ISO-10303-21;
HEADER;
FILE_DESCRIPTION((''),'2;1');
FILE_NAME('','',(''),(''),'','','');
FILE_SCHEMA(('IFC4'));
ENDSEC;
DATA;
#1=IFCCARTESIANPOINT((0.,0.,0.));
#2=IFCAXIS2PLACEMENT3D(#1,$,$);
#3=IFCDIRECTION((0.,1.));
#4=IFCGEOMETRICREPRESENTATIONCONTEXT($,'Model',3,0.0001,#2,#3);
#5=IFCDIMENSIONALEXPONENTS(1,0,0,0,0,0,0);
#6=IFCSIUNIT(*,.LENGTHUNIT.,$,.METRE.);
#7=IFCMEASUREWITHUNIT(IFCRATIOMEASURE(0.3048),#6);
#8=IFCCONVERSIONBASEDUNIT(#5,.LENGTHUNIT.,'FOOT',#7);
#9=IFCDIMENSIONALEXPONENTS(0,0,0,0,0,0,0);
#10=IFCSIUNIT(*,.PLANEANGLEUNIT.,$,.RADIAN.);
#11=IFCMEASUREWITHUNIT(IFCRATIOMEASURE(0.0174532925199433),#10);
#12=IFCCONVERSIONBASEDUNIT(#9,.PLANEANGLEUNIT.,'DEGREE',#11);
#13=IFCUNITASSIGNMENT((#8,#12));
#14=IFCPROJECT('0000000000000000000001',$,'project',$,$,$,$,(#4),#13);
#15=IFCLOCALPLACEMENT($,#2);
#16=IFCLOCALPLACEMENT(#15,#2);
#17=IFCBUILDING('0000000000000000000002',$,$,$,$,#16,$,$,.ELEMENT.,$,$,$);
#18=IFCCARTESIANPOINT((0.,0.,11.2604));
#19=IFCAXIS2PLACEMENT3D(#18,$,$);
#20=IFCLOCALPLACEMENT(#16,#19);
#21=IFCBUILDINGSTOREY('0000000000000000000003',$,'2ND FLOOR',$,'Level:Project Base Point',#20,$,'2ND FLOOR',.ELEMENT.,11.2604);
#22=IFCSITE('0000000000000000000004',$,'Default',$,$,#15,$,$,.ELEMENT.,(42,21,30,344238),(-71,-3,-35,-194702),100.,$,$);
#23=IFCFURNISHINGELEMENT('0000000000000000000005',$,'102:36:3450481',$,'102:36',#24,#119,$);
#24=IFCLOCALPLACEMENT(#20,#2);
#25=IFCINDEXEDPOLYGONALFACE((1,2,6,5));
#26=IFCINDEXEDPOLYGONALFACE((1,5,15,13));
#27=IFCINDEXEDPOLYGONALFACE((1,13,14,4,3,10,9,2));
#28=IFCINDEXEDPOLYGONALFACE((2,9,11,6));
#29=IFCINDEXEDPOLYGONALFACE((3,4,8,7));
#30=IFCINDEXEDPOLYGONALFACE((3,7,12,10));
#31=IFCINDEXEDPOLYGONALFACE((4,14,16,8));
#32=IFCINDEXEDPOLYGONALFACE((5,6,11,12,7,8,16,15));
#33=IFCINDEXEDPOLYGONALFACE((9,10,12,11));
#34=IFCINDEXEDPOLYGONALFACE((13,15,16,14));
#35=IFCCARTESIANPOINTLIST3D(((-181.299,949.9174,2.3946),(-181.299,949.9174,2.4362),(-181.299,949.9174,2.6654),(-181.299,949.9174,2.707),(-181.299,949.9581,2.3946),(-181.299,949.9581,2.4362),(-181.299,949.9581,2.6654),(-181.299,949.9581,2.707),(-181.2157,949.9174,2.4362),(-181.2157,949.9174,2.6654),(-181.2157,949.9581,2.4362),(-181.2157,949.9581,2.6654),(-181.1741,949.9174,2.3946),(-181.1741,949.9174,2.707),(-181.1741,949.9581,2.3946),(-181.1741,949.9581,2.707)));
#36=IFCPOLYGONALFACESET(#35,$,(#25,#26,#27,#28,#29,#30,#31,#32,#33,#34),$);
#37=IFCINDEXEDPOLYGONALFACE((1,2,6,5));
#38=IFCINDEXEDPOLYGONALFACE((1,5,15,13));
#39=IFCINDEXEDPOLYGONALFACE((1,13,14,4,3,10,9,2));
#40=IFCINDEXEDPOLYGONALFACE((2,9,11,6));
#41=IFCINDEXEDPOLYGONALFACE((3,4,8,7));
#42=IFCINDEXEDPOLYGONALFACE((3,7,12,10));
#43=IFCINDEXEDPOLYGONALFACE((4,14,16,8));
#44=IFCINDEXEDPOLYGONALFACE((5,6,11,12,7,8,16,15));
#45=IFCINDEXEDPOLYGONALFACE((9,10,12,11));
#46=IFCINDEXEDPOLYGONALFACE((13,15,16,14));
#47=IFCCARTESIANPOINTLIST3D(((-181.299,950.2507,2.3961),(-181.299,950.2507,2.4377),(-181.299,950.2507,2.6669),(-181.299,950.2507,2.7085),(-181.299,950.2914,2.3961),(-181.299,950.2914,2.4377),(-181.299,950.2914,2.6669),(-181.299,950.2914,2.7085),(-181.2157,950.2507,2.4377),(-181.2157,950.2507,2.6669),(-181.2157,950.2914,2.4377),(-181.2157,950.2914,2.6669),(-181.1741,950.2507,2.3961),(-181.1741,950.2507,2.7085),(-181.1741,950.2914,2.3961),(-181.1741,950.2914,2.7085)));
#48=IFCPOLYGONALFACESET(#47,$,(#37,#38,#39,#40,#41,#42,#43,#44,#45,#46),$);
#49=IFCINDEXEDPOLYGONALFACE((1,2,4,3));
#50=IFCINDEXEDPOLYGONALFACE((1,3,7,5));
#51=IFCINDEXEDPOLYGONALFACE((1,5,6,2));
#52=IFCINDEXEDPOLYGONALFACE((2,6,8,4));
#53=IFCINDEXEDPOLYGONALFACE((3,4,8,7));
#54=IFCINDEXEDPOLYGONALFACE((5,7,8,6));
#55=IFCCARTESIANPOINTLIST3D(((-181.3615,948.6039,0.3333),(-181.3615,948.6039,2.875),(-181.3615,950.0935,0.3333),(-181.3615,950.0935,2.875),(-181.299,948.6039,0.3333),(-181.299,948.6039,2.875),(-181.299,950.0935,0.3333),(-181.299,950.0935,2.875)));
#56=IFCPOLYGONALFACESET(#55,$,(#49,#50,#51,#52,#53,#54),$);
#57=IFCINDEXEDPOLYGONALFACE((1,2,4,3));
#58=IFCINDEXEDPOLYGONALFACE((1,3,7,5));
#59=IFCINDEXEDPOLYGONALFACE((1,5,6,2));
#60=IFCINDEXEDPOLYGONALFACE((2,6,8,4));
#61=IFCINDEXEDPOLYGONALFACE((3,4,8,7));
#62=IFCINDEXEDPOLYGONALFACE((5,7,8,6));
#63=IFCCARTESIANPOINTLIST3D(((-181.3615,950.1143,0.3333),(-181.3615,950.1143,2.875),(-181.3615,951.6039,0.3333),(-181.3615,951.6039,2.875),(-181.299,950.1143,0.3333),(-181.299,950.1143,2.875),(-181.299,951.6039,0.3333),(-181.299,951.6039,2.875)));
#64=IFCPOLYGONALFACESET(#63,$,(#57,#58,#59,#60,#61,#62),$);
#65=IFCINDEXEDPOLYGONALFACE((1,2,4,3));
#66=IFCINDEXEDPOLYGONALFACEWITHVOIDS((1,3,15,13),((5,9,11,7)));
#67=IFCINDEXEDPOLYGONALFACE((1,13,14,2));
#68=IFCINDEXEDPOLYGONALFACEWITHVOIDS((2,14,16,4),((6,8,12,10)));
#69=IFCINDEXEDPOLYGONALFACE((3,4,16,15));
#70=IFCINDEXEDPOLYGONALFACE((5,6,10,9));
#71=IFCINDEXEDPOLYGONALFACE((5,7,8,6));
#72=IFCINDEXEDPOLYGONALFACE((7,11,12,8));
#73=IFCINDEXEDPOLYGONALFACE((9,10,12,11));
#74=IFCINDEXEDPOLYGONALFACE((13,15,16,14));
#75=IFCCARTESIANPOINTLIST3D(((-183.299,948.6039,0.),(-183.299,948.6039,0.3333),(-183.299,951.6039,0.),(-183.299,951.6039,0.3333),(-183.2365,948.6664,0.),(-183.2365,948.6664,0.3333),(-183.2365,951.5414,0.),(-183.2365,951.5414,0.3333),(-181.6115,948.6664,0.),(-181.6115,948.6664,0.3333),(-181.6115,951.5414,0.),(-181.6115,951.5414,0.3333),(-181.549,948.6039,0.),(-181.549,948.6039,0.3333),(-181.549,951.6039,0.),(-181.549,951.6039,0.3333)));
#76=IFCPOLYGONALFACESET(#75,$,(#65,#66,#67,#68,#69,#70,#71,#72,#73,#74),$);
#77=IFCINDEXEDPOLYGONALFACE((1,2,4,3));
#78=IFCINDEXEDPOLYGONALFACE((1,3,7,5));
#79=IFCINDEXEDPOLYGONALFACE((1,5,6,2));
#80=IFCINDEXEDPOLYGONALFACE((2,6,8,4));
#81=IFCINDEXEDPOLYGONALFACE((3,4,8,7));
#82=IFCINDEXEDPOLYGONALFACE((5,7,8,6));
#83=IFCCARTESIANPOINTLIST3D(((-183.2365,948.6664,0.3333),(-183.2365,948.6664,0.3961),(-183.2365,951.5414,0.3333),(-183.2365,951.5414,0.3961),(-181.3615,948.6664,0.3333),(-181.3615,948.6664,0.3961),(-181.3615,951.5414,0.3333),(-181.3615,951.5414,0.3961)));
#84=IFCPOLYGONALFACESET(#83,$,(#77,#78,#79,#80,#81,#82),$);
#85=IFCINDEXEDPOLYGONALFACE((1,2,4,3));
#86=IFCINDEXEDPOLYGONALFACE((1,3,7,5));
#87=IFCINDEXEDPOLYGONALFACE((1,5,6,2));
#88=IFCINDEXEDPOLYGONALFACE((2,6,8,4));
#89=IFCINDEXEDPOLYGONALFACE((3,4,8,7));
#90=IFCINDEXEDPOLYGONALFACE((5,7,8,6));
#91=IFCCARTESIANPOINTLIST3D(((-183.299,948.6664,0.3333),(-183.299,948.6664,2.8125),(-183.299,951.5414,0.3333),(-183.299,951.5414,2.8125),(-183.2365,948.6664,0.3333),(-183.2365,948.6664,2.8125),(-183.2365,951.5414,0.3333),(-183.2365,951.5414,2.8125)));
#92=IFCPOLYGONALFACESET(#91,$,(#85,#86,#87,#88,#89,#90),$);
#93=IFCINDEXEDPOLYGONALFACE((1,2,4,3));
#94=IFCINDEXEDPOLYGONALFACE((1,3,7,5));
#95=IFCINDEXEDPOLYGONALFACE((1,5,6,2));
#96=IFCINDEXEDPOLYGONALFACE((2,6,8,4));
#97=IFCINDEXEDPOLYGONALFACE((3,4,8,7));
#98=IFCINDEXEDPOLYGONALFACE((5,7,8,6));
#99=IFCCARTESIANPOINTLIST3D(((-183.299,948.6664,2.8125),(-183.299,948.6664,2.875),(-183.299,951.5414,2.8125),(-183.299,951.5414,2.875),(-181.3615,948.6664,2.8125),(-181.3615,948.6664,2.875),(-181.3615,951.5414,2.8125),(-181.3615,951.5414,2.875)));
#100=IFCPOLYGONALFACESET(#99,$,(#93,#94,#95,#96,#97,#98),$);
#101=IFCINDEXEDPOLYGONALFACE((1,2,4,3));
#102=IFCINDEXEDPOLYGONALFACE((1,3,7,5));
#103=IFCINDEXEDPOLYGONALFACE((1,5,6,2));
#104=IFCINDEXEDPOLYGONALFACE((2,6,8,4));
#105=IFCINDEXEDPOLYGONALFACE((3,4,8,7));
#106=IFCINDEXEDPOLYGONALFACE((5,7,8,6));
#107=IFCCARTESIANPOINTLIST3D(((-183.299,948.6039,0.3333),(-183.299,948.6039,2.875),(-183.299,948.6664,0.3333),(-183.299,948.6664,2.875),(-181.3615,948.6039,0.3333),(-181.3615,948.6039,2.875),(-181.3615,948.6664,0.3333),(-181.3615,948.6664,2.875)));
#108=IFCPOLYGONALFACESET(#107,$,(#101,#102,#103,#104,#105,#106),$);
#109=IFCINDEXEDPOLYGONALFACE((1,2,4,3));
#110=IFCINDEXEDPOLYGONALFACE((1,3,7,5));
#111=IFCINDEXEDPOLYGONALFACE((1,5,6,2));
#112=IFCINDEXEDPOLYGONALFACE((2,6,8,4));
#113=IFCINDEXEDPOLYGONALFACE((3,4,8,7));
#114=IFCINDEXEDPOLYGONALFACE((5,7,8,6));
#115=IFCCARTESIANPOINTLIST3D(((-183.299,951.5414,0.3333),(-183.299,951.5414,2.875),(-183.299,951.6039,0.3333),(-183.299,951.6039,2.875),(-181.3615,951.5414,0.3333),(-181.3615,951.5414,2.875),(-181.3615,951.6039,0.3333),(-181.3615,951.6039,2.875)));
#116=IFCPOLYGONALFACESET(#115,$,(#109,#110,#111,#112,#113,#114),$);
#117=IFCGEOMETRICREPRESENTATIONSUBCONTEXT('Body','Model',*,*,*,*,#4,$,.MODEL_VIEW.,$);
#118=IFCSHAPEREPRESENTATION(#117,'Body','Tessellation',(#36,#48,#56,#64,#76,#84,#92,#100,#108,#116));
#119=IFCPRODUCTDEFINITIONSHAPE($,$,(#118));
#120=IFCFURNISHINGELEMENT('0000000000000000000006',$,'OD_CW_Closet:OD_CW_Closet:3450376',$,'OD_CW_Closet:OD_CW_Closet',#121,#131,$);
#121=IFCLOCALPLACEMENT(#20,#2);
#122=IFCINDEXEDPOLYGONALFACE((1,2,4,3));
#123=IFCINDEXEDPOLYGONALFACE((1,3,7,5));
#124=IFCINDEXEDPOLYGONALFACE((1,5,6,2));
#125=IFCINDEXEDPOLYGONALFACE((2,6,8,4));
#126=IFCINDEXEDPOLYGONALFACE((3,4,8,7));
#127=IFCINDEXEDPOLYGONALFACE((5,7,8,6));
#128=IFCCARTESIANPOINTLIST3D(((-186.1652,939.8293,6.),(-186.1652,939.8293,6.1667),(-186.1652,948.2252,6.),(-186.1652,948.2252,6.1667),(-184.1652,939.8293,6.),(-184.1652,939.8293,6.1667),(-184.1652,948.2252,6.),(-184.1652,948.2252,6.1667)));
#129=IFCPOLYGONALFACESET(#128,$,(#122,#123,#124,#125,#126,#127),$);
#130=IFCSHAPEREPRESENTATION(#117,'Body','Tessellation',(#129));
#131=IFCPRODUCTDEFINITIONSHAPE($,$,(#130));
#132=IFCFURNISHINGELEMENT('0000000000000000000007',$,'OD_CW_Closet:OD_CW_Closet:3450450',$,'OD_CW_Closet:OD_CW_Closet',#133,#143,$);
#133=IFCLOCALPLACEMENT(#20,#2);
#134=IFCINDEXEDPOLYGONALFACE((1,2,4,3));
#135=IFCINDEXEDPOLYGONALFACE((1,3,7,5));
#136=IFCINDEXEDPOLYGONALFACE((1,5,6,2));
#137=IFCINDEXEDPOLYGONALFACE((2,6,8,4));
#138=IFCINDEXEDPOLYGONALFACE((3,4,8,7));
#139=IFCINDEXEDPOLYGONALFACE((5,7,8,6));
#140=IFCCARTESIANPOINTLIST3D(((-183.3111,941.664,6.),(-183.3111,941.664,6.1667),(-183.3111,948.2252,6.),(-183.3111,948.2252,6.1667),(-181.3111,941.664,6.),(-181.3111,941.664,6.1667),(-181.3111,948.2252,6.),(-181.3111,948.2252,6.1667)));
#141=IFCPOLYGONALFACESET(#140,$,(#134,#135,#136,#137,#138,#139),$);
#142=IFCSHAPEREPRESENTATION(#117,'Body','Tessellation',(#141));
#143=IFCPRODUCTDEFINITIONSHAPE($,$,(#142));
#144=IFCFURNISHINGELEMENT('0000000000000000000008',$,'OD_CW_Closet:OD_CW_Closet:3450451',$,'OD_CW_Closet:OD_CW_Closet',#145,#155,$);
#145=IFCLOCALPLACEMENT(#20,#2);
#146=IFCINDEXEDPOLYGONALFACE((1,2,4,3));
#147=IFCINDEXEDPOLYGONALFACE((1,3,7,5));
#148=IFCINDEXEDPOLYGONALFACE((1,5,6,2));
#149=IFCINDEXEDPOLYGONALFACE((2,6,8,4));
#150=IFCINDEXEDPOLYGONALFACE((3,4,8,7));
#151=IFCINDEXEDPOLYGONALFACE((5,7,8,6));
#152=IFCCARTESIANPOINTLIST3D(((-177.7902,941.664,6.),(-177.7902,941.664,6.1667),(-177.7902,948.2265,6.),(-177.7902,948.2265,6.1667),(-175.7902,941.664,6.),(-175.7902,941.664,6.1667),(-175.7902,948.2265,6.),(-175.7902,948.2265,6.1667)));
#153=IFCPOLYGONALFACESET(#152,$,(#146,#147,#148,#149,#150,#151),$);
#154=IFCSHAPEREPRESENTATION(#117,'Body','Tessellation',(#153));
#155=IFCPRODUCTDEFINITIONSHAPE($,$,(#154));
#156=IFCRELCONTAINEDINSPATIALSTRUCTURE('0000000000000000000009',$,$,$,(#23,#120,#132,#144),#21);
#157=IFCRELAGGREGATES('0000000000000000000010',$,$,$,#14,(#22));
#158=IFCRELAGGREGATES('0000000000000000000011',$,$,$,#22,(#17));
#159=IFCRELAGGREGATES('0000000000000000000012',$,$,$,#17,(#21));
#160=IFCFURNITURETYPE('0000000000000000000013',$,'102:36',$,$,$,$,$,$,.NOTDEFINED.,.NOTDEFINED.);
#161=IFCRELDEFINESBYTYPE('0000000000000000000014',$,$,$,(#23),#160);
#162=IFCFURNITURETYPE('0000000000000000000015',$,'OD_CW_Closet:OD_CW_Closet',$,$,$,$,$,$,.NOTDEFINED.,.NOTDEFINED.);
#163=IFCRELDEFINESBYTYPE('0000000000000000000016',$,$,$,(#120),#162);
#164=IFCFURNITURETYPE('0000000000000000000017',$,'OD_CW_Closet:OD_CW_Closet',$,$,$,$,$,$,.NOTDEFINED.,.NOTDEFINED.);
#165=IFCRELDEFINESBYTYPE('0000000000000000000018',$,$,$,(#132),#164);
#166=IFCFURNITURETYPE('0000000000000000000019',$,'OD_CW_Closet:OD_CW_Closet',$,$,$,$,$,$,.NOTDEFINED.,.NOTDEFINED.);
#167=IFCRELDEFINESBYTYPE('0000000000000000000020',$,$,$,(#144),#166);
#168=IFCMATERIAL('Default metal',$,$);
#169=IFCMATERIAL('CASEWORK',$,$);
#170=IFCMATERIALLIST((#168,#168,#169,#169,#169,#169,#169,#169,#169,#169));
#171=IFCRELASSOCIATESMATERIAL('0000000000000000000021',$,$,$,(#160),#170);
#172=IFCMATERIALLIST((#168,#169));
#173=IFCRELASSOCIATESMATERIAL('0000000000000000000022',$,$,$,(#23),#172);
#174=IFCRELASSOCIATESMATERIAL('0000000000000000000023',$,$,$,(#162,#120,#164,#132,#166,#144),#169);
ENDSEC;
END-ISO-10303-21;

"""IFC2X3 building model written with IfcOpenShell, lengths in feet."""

from ifc_helpers import new_model, entity, si_unit, converted_unit, direction, frame, frame_2d, origin, origin_2d_with_axis, place, context, subcontext, project, spatial, polyline, rectangle, outline, extrude, source, transform, mapped, material, material_list, type_object, type_shapes, element, save


model = new_model("IFC2X3")

# Units and contexts
model_context = context("Model", 3, precision=0.0001, world=origin(), true_north=direction((0.0, 1.0)))
body_context = subcontext(model_context, "Body", "Model", "MODEL_VIEW")
ifc_project = project(units=[converted_unit("LENGTHUNIT", "FOOT", entity("IfcRatioMeasure", 0.3048), si_unit("LENGTHUNIT", "METRE"), dimensions=[1, 0, 0, 0, 0, 0, 0]), converted_unit("PLANEANGLEUNIT", "DEGREE", entity("IfcRatioMeasure", 0.0174532925199433), si_unit("PLANEANGLEUNIT", "RADIAN"), dimensions=[0, 0, 0, 0, 0, 0, 0])], contexts=[model_context])

# Site, building, storey
site_placement = place(None, origin())
site = spatial("IfcSite", under=ifc_project, at=site_placement, Name="Default", CompositionType="ELEMENT", RefLatitude=(42, 21, 30, 344238), RefLongitude=(-71, -3, -35, -194702), RefElevation=100.0)
building_placement = place(site_placement, origin())
building = spatial("IfcBuilding", under=site, at=building_placement, CompositionType="ELEMENT")
storey_placement = place(building_placement, frame((0.0, 0.0, 11.2604)))
storey = spatial("IfcBuildingStorey", under=building, at=storey_placement, Name="2ND FLOOR", ObjectType="Level:Project Base Point", LongName="2ND FLOOR", CompositionType="ELEMENT", Elevation=11.2604)

# Furnishing elements
ifc_material_1 = material(Name="Default metal")
ifc_material_2 = material(Name="CASEWORK")
ifc_material_list_1 = material_list([ifc_material_1, ifc_material_1, ifc_material_2, ifc_material_2, ifc_material_2, ifc_material_2, ifc_material_2, ifc_material_2, ifc_material_2, ifc_material_2])
furniture_type_1 = type_object("IfcFurnitureType", Name="102:36", material=ifc_material_list_1)
shared_shape_1 = source(origin(), body_context, "Body", "SweptSolid", [
    extrude(outline(polyline([(-0.0521, -0.1146), (-0.0521, -0.1562), (0.0729, -0.1562), (0.0729, 0.1562), (-0.0521, 0.1562), (-0.0521, 0.1146), (0.0313, 0.1146), (0.0313, -0.1146), (-0.0521, -0.1146)])), frame((0.2073, 2.0521, 2.5508), z_axis=(-1.0, 0.0, 0.0), x_axis=(0.0, 1.0, 0.0)), (0.0, 0.0, -1.0), 0.0407),
    extrude(outline(polyline([(-0.0521, -0.1146), (-0.0521, -0.1562), (0.0729, -0.1562), (0.0729, 0.1562), (-0.0521, 0.1562), (-0.0521, 0.1146), (0.0313, 0.1146), (0.0313, -0.1146), (-0.0521, -0.1146)])), frame((-0.126, 2.0521, 2.5523), z_axis=(-1.0, 0.0, 0.0), x_axis=(0.0, 1.0, 0.0)), (0.0, 0.0, -1.0), 0.0407),
    extrude(rectangle(XDim=1.4896, YDim=0.0625, at=frame_2d((0.0, 0.0), x_axis=(1.0, 0.0))), frame((0.8167, 1.9688, 0.3333), z_axis=(0.0, 0.0, 1.0), x_axis=(-1.0, 0.0, 0.0)), (0.0, 0.0, 1.0), 2.5417),
    extrude(rectangle(XDim=1.4896, YDim=0.0625, at=origin_2d_with_axis()), frame((-0.6937, 1.9688, 0.3333), z_axis=(0.0, 0.0, 1.0), x_axis=(-1.0, 0.0, 0.0)), (0.0, 0.0, 1.0), 2.5417),
    extrude(outline(polyline([(-0.875, -1.5), (0.875, -1.5), (0.875, 1.5), (-0.875, 1.5), (-0.875, -1.5)]), holes=[polyline([(-0.8125, -1.4375), (-0.8125, 1.4375), (0.8125, 1.4375), (0.8125, -1.4375), (-0.8125, -1.4375)])]), frame((0.0615, 0.875, 0.0), z_axis=(0.0, 0.0, 1.0), x_axis=(0.0, -1.0, 0.0)), (0.0, 0.0, 1.0), 0.3333),
    extrude(rectangle(XDim=1.875, YDim=2.875, at=origin_2d_with_axis()), frame((0.0615, 1.0, 0.3333), z_axis=(0.0, 0.0, 1.0), x_axis=(0.0, 1.0, 0.0)), (0.0, 0.0, 1.0), 0.0627),
    extrude(rectangle(XDim=2.875, YDim=0.0625, at=origin_2d_with_axis()), frame((0.0615, 0.0312, 0.3333), z_axis=(0.0, 0.0, 1.0), x_axis=(-1.0, 0.0, 0.0)), (0.0, 0.0, 1.0), 2.4792),
    extrude(rectangle(XDim=1.9375, YDim=2.875, at=frame_2d((0.0, 0.0), x_axis=(1.0, 0.0))), frame((0.0615, 0.9688, 2.8125), z_axis=(0.0, 0.0, 1.0), x_axis=(0.0, 1.0, 0.0)), (0.0, 0.0, 1.0), 0.0625),
    extrude(rectangle(XDim=1.9375, YDim=0.0625, at=frame_2d((0.0, 0.0), x_axis=(1.0, 0.0))), frame((1.5302, 0.9687, 0.3333), z_axis=(0.0, 0.0, 1.0), x_axis=(0.0, -1.0, 0.0)), (0.0, 0.0, 1.0), 2.5417),
    extrude(rectangle(XDim=1.9375, YDim=0.0625, at=frame_2d((0.0, 0.0), x_axis=(1.0, 0.0))), frame((-1.4073, 0.9687, 0.3333), z_axis=(0.0, 0.0, 1.0), x_axis=(0.0, -1.0, 0.0)), (0.0, 0.0, 1.0), 2.5417),
])
type_shapes(furniture_type_1, [shared_shape_1])
ifc_material_list_2 = material_list([ifc_material_1, ifc_material_2])
furnishing_1_placement = place(storey_placement, frame((-183.299, 950.1654, 0.0), z_axis=(0.0, 0.0, 1.0), x_axis=(0.0, -1.0, 0.0)))
element("IfcFurnishingElement", 1, at=furnishing_1_placement, inside=storey, type_object=furniture_type_1, material=ifc_material_list_2, Name="102:36:3450481", ObjectType="102:36", context=body_context, shape_type="MappedRepresentation", body=[
    mapped(shared_shape_1, transform((0.0, 0.0, 0.0), scale=1.0)),
])
furniture_type_2 = type_object("IfcFurnitureType", Name="OD_CW_Closet:OD_CW_Closet", material=ifc_material_2)
shared_shape_2 = source(origin(), body_context, "Body", "SweptSolid", [
    extrude(rectangle(XDim=2.0, YDim=8.3958, at=frame_2d((0.0, 0.0), x_axis=(1.0, 0.0))), frame((4.1979, 1.0, 0.0), z_axis=(0.0, 0.0, 1.0), x_axis=(0.0, -1.0, 0.0)), (0.0, 0.0, 1.0), 0.1667),
])
type_shapes(furniture_type_2, [shared_shape_2])
furnishing_2_placement = place(storey_placement, frame((-186.1652, 948.2252, 6.0), z_axis=(0.0, 0.0, 1.0), x_axis=(0.0, -1.0, 0.0)))
element("IfcFurnishingElement", 2, at=furnishing_2_placement, inside=storey, type_object=furniture_type_2, material=ifc_material_2, Name="OD_CW_Closet:OD_CW_Closet:3450376", ObjectType="OD_CW_Closet:OD_CW_Closet", context=body_context, shape_type="MappedRepresentation", body=[
    mapped(shared_shape_2, transform((0.0, 0.0, 0.0), scale=1.0)),
])
furniture_type_3 = type_object("IfcFurnitureType", Name="OD_CW_Closet:OD_CW_Closet", material=ifc_material_2)
shared_shape_3 = source(origin(), body_context, "Body", "SweptSolid", [
    extrude(rectangle(XDim=6.5611, YDim=2.0, at=origin_2d_with_axis()), frame((3.2806, 1.0, 0.0)), (0.0, 0.0, 1.0), 0.1667),
])
type_shapes(furniture_type_3, [shared_shape_3])
furnishing_3_placement = place(storey_placement, frame((-183.3111, 948.2252, 6.0), z_axis=(0.0, 0.0, 1.0), x_axis=(0.0, -1.0, 0.0)))
element("IfcFurnishingElement", 3, at=furnishing_3_placement, inside=storey, type_object=furniture_type_3, material=ifc_material_2, Name="OD_CW_Closet:OD_CW_Closet:3450450", ObjectType="OD_CW_Closet:OD_CW_Closet", context=body_context, shape_type="MappedRepresentation", body=[
    mapped(shared_shape_3, transform((0.0, 0.0, 0.0), scale=1.0)),
])
furniture_type_4 = type_object("IfcFurnitureType", Name="OD_CW_Closet:OD_CW_Closet", material=ifc_material_2)
shared_shape_4 = source(origin(), body_context, "Body", "SweptSolid", [
    extrude(rectangle(XDim=2.0, YDim=6.5625, at=origin_2d_with_axis()), frame((3.2813, 1.0, 0.0), z_axis=(0.0, 0.0, 1.0), x_axis=(0.0, -1.0, 0.0)), (0.0, 0.0, 1.0), 0.1667),
])
type_shapes(furniture_type_4, [shared_shape_4])
furnishing_4_placement = place(storey_placement, frame((-177.7902, 948.2265, 6.0), z_axis=(0.0, 0.0, 1.0), x_axis=(0.0, -1.0, 0.0)))
element("IfcFurnishingElement", 4, at=furnishing_4_placement, inside=storey, type_object=furniture_type_4, material=ifc_material_2, Name="OD_CW_Closet:OD_CW_Closet:3450451", ObjectType="OD_CW_Closet:OD_CW_Closet", context=body_context, shape_type="MappedRepresentation", body=[
    mapped(shared_shape_4, transform((0.0, 0.0, 0.0), scale=1.0)),
])

save(model, "model.ifc")
